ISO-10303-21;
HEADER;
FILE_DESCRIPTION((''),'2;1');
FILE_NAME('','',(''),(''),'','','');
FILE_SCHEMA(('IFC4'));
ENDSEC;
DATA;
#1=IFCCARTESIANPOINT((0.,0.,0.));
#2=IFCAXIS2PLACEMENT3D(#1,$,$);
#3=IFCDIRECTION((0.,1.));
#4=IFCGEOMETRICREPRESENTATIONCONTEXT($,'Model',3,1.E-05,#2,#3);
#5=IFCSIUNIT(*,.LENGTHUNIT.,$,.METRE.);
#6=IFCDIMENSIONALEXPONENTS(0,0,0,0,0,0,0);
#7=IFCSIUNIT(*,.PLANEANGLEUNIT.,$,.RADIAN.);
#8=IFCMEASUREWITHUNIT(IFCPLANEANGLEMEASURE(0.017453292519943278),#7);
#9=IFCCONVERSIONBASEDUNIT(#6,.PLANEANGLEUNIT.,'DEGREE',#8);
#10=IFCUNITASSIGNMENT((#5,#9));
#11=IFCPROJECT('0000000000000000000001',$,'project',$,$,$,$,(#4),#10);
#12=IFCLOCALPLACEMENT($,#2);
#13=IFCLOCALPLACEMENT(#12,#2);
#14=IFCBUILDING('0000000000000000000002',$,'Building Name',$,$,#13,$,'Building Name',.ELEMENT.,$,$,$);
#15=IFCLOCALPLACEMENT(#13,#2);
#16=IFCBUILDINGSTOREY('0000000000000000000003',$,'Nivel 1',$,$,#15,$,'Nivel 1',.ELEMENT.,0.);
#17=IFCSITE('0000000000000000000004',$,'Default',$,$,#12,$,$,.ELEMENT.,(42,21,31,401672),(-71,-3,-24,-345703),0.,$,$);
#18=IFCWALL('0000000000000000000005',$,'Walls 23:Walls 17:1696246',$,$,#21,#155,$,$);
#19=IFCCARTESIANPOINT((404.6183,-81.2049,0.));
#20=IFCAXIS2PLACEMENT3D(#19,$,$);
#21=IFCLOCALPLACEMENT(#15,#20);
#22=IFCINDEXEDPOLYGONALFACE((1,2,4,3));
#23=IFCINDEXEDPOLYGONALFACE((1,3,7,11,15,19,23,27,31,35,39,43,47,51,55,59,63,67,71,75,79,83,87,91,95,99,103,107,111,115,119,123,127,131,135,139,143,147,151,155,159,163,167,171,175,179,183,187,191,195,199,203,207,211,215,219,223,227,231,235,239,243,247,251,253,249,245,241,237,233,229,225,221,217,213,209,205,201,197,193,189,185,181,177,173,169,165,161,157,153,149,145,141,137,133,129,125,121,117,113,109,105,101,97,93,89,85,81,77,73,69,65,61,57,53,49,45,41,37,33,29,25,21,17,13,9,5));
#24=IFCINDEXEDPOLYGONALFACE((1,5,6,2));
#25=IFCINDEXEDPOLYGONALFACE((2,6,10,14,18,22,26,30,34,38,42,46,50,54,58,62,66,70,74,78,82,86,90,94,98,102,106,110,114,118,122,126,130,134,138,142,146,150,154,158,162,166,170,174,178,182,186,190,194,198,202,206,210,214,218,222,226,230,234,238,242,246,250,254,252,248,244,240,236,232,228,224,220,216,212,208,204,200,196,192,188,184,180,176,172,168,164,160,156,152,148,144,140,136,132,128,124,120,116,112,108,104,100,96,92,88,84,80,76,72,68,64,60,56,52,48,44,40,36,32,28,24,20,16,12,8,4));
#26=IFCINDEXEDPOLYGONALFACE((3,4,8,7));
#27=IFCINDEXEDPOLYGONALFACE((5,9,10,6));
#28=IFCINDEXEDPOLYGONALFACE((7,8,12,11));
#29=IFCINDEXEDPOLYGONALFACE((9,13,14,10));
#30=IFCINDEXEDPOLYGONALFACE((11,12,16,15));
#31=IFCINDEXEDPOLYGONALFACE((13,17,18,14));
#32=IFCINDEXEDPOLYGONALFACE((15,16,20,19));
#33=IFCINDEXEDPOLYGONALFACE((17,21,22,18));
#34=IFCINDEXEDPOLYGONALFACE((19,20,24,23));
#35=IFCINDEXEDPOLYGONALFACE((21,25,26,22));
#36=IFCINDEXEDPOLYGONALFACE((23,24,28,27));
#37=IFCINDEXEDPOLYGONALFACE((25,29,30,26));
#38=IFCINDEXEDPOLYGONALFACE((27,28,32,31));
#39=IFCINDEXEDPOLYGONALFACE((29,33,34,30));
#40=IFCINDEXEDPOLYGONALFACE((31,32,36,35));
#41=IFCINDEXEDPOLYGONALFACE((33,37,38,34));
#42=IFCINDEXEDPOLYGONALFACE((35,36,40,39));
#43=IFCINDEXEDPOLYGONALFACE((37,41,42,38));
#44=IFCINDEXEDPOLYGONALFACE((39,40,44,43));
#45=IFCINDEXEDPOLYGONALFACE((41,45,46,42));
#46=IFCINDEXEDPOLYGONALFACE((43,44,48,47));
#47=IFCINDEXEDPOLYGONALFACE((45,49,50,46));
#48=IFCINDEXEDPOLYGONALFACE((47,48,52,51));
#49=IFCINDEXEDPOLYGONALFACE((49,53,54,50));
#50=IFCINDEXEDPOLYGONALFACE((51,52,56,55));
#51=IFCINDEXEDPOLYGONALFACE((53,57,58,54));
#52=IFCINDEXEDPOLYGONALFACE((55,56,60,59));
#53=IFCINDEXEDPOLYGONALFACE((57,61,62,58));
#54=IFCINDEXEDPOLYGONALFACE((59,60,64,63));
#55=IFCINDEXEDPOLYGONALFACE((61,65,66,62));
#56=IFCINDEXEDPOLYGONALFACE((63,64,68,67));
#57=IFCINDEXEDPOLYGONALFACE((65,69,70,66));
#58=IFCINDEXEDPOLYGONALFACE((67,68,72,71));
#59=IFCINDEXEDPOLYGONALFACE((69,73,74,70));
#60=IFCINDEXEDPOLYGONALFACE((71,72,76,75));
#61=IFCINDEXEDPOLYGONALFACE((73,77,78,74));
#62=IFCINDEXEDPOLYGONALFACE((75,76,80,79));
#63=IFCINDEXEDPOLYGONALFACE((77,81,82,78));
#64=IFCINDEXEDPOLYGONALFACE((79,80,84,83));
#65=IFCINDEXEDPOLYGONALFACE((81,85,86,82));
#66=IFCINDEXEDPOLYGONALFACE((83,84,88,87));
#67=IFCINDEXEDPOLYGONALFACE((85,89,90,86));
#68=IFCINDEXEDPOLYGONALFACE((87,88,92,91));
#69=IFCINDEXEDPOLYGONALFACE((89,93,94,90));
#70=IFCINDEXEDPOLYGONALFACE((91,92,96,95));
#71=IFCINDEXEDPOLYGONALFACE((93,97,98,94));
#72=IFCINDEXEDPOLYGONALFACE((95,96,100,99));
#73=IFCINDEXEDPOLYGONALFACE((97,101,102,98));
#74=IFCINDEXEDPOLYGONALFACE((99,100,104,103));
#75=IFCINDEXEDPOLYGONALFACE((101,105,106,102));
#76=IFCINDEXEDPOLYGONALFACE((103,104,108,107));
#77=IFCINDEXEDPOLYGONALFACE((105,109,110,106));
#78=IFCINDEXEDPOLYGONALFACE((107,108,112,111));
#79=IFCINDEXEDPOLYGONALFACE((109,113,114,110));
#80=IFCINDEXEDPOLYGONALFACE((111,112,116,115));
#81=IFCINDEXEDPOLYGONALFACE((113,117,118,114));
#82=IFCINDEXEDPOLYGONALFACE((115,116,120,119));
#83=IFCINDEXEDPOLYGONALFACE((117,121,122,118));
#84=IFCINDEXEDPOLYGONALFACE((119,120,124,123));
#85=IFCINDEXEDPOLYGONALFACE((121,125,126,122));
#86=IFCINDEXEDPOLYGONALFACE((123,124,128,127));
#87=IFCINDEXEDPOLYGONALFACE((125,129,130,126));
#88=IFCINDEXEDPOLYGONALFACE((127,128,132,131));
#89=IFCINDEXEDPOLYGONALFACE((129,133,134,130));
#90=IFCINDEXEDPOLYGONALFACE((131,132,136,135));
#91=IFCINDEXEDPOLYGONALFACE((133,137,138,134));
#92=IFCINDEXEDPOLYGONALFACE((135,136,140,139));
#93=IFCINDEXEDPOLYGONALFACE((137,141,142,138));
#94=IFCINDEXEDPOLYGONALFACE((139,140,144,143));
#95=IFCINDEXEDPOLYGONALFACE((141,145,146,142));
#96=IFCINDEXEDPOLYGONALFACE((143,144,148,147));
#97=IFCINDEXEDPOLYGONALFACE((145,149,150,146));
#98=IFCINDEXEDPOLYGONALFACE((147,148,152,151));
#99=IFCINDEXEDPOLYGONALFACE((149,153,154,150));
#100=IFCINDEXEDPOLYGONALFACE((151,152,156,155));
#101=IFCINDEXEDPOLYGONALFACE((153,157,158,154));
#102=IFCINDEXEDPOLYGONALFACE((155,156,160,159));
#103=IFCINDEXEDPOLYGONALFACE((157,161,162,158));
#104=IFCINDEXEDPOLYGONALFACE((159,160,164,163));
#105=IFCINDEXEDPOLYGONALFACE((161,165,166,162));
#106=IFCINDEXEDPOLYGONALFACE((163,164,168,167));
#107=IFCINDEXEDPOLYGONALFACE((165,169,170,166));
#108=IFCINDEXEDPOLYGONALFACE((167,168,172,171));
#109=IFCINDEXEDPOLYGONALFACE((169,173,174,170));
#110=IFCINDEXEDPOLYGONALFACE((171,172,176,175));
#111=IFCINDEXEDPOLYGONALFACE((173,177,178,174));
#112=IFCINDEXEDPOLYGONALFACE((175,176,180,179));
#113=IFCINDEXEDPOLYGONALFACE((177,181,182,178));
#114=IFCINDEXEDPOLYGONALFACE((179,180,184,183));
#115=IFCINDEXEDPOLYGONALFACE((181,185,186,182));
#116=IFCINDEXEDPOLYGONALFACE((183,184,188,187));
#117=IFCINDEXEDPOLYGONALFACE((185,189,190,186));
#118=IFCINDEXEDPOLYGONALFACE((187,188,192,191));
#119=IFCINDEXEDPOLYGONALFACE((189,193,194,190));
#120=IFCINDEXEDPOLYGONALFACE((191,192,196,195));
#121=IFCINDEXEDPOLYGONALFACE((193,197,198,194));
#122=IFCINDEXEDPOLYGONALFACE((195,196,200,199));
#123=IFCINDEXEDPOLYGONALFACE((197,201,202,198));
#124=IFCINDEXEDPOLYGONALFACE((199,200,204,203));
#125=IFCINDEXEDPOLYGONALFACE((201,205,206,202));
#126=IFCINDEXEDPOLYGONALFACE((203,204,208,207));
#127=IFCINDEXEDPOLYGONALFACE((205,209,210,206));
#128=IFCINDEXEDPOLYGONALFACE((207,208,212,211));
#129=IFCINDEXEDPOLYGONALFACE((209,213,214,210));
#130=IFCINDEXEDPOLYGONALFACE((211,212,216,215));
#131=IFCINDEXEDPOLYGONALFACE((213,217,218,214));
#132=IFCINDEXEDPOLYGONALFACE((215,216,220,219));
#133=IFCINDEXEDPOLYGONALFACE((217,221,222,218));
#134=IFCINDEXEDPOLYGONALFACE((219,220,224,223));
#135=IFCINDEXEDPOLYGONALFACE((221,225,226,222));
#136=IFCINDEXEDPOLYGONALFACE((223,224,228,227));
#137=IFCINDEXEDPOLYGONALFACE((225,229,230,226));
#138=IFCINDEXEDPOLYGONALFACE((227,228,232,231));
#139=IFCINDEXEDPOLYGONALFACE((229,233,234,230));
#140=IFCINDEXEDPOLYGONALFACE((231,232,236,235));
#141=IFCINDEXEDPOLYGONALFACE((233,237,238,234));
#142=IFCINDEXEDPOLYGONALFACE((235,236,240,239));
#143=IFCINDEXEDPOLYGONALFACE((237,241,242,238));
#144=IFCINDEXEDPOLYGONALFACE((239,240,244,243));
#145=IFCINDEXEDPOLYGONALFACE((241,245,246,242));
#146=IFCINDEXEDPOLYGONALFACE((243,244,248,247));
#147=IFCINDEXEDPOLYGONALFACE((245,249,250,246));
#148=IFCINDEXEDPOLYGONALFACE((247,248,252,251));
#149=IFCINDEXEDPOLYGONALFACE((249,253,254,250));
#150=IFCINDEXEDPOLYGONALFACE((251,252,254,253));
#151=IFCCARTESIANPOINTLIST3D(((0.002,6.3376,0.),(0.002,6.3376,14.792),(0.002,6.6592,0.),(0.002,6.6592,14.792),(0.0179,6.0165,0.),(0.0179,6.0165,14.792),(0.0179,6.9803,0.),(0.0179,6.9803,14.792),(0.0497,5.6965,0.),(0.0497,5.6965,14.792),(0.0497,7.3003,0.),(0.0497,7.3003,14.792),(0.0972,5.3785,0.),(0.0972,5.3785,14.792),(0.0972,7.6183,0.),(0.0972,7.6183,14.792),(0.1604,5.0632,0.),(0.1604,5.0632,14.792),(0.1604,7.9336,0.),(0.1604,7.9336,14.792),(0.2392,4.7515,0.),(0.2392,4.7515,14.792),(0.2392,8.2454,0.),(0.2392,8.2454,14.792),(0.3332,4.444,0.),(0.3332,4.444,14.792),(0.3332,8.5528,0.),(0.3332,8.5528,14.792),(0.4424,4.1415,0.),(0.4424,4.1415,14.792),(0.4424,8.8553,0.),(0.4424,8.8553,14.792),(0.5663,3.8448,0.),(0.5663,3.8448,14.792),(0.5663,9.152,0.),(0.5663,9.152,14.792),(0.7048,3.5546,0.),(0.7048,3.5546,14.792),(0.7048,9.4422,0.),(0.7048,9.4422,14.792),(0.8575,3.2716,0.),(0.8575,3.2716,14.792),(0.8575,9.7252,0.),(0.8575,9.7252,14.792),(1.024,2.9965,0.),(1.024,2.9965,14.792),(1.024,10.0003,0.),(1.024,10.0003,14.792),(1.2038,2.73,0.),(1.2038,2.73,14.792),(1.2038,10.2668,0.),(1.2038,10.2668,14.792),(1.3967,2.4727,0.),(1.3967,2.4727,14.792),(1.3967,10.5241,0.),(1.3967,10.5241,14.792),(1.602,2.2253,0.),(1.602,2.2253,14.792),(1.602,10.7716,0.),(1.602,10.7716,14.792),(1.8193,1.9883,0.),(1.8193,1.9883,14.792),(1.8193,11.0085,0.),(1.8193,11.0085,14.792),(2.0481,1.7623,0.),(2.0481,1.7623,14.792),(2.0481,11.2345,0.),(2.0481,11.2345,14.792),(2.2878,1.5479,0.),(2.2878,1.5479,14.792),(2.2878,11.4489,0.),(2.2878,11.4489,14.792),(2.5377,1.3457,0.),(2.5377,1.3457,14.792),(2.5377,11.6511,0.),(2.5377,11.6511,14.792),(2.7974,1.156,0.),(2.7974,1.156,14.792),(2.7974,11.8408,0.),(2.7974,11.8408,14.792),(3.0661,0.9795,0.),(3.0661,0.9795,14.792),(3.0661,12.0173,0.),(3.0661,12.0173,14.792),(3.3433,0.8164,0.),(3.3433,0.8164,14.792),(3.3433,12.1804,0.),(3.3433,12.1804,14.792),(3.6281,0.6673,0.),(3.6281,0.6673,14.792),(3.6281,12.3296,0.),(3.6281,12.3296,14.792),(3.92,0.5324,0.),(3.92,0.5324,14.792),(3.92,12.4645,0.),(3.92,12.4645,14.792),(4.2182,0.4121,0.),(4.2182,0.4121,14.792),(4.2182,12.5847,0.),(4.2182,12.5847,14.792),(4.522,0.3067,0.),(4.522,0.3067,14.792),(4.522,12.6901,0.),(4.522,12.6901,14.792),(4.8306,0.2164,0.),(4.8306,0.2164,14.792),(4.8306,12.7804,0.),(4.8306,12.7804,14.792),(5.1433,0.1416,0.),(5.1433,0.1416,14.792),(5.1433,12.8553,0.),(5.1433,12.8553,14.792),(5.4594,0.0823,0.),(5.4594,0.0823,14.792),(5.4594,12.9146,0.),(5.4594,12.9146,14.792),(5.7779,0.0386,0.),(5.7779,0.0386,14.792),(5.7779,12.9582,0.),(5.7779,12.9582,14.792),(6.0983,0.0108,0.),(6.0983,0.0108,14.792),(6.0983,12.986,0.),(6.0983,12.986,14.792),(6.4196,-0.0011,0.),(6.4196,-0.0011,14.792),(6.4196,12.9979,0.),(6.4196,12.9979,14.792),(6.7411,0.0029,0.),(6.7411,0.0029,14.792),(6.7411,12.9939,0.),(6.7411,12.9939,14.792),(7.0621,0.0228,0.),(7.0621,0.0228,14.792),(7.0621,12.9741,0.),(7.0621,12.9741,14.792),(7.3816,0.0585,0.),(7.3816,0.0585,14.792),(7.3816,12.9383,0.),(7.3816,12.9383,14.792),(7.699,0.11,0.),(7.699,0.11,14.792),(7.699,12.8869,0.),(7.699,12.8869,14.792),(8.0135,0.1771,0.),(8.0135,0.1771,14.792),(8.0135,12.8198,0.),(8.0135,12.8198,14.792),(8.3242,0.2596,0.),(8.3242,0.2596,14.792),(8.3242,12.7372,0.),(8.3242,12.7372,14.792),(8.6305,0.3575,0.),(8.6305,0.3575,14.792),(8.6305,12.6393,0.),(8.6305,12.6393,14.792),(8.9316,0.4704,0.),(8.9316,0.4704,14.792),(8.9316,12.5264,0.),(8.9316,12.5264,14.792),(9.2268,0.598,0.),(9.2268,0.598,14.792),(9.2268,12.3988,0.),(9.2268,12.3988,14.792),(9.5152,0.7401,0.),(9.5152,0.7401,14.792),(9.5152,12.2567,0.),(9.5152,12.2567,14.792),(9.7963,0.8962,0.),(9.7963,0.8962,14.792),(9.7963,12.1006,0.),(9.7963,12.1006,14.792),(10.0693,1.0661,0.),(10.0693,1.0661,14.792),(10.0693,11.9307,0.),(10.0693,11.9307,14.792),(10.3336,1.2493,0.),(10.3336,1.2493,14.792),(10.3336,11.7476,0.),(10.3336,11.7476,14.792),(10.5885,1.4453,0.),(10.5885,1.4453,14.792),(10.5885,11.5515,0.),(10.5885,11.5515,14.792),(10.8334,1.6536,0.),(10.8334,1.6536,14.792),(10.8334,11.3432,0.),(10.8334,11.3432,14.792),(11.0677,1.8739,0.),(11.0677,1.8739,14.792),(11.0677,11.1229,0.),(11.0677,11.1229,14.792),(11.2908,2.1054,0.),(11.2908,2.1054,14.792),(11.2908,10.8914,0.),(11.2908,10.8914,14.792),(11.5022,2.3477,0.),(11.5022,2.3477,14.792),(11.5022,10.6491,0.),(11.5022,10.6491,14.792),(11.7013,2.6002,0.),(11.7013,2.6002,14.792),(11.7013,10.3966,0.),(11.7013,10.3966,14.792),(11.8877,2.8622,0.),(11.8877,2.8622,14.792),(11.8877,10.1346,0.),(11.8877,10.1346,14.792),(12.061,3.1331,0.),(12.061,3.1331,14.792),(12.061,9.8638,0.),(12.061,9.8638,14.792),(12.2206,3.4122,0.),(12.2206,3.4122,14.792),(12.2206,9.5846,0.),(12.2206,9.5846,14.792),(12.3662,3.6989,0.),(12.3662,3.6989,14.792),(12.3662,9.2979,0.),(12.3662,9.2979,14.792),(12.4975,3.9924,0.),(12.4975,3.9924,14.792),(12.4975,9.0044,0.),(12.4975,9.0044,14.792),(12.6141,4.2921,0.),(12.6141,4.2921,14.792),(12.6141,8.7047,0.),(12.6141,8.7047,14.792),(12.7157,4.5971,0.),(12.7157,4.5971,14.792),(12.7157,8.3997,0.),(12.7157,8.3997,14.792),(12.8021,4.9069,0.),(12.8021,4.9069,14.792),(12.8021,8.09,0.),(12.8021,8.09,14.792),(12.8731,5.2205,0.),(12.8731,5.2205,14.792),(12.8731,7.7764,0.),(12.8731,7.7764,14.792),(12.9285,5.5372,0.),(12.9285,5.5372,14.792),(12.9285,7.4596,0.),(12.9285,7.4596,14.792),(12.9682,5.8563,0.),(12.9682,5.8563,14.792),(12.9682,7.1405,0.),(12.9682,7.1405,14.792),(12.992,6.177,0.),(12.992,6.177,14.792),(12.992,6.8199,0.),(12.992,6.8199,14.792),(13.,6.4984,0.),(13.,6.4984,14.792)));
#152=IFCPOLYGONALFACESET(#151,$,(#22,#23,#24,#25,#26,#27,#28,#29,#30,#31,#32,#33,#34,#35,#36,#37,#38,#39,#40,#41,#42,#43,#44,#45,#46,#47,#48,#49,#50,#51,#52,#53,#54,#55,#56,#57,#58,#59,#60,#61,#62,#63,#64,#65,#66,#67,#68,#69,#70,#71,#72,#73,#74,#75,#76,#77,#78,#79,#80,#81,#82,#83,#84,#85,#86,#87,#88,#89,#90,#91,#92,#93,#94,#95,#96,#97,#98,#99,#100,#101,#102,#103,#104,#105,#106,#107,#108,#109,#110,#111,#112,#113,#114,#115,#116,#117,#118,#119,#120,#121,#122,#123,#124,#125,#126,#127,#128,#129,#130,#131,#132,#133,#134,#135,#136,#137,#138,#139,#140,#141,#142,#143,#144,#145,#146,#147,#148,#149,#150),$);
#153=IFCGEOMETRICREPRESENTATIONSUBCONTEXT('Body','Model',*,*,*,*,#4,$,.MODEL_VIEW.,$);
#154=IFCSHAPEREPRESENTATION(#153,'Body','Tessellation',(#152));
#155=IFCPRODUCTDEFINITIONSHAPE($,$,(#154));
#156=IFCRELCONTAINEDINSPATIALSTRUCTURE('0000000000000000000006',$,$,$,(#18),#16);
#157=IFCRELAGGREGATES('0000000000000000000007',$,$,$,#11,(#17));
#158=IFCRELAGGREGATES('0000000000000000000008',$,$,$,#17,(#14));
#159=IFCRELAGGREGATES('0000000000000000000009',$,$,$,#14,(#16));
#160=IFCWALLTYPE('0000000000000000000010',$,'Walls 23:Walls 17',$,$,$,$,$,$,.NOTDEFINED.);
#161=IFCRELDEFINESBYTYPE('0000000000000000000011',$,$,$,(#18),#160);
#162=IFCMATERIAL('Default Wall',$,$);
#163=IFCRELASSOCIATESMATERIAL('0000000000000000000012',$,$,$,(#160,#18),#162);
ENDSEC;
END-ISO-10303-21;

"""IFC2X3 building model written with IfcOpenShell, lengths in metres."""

from ifc_helpers import new_model, entity, si_unit, converted_unit, direction, frame, frame_2d, origin, place, context, subcontext, project, spatial, circle, extrude, material, type_object, element, save


model = new_model("IFC2X3")

# Units and contexts
model_context = context("Model", 3, precision=1e-05, world=origin(), true_north=direction((0.0, 1.0)))
body_context = subcontext(model_context, "Body", "Model", "MODEL_VIEW")
ifc_project = project(units=[si_unit("LENGTHUNIT", "METRE"), converted_unit("PLANEANGLEUNIT", "DEGREE", entity("IfcPlaneAngleMeasure", 0.017453292519943278), si_unit("PLANEANGLEUNIT", "RADIAN"), dimensions=[0, 0, 0, 0, 0, 0, 0])], contexts=[model_context])

# Site, building, storey
site_placement = place(None, origin())
site = spatial("IfcSite", under=ifc_project, at=site_placement, Name="Default", CompositionType="ELEMENT", RefLatitude=(42, 21, 31, 401672), RefLongitude=(-71, -3, -24, -345703), RefElevation=0.0)
building_placement = place(site_placement, origin())
building = spatial("IfcBuilding", under=site, at=building_placement, Name="Building Name", LongName="Building Name", CompositionType="ELEMENT")
storey_placement = place(building_placement, origin())
storey = spatial("IfcBuildingStorey", under=building, at=storey_placement, Name="Nivel 1", LongName="Nivel 1", CompositionType="ELEMENT", Elevation=0.0)

# Wall
ifc_material_1 = material(Name="Default Wall")
wall_type_1 = type_object("IfcWallType", Name="Walls 23:Walls 17", PredefinedType="NOTDEFINED", material=ifc_material_1)
wall_1_placement = place(storey_placement, frame((404.6183, -81.2049, 0.0)))
element("IfcWall", 1, at=wall_1_placement, inside=storey, type_object=wall_type_1, material=ifc_material_1, Name="Walls 23:Walls 17:1696246", context=body_context, shape_type="SweptSolid", body=[
    extrude(circle(Radius=6.5, at=frame_2d((0.0, 0.0), x_axis=(1.0, 0.0))), frame((6.5, 6.4984, 0.0)), (0.0, 0.0, 1.0), 14.792),
])

save(model, "model.ifc")
